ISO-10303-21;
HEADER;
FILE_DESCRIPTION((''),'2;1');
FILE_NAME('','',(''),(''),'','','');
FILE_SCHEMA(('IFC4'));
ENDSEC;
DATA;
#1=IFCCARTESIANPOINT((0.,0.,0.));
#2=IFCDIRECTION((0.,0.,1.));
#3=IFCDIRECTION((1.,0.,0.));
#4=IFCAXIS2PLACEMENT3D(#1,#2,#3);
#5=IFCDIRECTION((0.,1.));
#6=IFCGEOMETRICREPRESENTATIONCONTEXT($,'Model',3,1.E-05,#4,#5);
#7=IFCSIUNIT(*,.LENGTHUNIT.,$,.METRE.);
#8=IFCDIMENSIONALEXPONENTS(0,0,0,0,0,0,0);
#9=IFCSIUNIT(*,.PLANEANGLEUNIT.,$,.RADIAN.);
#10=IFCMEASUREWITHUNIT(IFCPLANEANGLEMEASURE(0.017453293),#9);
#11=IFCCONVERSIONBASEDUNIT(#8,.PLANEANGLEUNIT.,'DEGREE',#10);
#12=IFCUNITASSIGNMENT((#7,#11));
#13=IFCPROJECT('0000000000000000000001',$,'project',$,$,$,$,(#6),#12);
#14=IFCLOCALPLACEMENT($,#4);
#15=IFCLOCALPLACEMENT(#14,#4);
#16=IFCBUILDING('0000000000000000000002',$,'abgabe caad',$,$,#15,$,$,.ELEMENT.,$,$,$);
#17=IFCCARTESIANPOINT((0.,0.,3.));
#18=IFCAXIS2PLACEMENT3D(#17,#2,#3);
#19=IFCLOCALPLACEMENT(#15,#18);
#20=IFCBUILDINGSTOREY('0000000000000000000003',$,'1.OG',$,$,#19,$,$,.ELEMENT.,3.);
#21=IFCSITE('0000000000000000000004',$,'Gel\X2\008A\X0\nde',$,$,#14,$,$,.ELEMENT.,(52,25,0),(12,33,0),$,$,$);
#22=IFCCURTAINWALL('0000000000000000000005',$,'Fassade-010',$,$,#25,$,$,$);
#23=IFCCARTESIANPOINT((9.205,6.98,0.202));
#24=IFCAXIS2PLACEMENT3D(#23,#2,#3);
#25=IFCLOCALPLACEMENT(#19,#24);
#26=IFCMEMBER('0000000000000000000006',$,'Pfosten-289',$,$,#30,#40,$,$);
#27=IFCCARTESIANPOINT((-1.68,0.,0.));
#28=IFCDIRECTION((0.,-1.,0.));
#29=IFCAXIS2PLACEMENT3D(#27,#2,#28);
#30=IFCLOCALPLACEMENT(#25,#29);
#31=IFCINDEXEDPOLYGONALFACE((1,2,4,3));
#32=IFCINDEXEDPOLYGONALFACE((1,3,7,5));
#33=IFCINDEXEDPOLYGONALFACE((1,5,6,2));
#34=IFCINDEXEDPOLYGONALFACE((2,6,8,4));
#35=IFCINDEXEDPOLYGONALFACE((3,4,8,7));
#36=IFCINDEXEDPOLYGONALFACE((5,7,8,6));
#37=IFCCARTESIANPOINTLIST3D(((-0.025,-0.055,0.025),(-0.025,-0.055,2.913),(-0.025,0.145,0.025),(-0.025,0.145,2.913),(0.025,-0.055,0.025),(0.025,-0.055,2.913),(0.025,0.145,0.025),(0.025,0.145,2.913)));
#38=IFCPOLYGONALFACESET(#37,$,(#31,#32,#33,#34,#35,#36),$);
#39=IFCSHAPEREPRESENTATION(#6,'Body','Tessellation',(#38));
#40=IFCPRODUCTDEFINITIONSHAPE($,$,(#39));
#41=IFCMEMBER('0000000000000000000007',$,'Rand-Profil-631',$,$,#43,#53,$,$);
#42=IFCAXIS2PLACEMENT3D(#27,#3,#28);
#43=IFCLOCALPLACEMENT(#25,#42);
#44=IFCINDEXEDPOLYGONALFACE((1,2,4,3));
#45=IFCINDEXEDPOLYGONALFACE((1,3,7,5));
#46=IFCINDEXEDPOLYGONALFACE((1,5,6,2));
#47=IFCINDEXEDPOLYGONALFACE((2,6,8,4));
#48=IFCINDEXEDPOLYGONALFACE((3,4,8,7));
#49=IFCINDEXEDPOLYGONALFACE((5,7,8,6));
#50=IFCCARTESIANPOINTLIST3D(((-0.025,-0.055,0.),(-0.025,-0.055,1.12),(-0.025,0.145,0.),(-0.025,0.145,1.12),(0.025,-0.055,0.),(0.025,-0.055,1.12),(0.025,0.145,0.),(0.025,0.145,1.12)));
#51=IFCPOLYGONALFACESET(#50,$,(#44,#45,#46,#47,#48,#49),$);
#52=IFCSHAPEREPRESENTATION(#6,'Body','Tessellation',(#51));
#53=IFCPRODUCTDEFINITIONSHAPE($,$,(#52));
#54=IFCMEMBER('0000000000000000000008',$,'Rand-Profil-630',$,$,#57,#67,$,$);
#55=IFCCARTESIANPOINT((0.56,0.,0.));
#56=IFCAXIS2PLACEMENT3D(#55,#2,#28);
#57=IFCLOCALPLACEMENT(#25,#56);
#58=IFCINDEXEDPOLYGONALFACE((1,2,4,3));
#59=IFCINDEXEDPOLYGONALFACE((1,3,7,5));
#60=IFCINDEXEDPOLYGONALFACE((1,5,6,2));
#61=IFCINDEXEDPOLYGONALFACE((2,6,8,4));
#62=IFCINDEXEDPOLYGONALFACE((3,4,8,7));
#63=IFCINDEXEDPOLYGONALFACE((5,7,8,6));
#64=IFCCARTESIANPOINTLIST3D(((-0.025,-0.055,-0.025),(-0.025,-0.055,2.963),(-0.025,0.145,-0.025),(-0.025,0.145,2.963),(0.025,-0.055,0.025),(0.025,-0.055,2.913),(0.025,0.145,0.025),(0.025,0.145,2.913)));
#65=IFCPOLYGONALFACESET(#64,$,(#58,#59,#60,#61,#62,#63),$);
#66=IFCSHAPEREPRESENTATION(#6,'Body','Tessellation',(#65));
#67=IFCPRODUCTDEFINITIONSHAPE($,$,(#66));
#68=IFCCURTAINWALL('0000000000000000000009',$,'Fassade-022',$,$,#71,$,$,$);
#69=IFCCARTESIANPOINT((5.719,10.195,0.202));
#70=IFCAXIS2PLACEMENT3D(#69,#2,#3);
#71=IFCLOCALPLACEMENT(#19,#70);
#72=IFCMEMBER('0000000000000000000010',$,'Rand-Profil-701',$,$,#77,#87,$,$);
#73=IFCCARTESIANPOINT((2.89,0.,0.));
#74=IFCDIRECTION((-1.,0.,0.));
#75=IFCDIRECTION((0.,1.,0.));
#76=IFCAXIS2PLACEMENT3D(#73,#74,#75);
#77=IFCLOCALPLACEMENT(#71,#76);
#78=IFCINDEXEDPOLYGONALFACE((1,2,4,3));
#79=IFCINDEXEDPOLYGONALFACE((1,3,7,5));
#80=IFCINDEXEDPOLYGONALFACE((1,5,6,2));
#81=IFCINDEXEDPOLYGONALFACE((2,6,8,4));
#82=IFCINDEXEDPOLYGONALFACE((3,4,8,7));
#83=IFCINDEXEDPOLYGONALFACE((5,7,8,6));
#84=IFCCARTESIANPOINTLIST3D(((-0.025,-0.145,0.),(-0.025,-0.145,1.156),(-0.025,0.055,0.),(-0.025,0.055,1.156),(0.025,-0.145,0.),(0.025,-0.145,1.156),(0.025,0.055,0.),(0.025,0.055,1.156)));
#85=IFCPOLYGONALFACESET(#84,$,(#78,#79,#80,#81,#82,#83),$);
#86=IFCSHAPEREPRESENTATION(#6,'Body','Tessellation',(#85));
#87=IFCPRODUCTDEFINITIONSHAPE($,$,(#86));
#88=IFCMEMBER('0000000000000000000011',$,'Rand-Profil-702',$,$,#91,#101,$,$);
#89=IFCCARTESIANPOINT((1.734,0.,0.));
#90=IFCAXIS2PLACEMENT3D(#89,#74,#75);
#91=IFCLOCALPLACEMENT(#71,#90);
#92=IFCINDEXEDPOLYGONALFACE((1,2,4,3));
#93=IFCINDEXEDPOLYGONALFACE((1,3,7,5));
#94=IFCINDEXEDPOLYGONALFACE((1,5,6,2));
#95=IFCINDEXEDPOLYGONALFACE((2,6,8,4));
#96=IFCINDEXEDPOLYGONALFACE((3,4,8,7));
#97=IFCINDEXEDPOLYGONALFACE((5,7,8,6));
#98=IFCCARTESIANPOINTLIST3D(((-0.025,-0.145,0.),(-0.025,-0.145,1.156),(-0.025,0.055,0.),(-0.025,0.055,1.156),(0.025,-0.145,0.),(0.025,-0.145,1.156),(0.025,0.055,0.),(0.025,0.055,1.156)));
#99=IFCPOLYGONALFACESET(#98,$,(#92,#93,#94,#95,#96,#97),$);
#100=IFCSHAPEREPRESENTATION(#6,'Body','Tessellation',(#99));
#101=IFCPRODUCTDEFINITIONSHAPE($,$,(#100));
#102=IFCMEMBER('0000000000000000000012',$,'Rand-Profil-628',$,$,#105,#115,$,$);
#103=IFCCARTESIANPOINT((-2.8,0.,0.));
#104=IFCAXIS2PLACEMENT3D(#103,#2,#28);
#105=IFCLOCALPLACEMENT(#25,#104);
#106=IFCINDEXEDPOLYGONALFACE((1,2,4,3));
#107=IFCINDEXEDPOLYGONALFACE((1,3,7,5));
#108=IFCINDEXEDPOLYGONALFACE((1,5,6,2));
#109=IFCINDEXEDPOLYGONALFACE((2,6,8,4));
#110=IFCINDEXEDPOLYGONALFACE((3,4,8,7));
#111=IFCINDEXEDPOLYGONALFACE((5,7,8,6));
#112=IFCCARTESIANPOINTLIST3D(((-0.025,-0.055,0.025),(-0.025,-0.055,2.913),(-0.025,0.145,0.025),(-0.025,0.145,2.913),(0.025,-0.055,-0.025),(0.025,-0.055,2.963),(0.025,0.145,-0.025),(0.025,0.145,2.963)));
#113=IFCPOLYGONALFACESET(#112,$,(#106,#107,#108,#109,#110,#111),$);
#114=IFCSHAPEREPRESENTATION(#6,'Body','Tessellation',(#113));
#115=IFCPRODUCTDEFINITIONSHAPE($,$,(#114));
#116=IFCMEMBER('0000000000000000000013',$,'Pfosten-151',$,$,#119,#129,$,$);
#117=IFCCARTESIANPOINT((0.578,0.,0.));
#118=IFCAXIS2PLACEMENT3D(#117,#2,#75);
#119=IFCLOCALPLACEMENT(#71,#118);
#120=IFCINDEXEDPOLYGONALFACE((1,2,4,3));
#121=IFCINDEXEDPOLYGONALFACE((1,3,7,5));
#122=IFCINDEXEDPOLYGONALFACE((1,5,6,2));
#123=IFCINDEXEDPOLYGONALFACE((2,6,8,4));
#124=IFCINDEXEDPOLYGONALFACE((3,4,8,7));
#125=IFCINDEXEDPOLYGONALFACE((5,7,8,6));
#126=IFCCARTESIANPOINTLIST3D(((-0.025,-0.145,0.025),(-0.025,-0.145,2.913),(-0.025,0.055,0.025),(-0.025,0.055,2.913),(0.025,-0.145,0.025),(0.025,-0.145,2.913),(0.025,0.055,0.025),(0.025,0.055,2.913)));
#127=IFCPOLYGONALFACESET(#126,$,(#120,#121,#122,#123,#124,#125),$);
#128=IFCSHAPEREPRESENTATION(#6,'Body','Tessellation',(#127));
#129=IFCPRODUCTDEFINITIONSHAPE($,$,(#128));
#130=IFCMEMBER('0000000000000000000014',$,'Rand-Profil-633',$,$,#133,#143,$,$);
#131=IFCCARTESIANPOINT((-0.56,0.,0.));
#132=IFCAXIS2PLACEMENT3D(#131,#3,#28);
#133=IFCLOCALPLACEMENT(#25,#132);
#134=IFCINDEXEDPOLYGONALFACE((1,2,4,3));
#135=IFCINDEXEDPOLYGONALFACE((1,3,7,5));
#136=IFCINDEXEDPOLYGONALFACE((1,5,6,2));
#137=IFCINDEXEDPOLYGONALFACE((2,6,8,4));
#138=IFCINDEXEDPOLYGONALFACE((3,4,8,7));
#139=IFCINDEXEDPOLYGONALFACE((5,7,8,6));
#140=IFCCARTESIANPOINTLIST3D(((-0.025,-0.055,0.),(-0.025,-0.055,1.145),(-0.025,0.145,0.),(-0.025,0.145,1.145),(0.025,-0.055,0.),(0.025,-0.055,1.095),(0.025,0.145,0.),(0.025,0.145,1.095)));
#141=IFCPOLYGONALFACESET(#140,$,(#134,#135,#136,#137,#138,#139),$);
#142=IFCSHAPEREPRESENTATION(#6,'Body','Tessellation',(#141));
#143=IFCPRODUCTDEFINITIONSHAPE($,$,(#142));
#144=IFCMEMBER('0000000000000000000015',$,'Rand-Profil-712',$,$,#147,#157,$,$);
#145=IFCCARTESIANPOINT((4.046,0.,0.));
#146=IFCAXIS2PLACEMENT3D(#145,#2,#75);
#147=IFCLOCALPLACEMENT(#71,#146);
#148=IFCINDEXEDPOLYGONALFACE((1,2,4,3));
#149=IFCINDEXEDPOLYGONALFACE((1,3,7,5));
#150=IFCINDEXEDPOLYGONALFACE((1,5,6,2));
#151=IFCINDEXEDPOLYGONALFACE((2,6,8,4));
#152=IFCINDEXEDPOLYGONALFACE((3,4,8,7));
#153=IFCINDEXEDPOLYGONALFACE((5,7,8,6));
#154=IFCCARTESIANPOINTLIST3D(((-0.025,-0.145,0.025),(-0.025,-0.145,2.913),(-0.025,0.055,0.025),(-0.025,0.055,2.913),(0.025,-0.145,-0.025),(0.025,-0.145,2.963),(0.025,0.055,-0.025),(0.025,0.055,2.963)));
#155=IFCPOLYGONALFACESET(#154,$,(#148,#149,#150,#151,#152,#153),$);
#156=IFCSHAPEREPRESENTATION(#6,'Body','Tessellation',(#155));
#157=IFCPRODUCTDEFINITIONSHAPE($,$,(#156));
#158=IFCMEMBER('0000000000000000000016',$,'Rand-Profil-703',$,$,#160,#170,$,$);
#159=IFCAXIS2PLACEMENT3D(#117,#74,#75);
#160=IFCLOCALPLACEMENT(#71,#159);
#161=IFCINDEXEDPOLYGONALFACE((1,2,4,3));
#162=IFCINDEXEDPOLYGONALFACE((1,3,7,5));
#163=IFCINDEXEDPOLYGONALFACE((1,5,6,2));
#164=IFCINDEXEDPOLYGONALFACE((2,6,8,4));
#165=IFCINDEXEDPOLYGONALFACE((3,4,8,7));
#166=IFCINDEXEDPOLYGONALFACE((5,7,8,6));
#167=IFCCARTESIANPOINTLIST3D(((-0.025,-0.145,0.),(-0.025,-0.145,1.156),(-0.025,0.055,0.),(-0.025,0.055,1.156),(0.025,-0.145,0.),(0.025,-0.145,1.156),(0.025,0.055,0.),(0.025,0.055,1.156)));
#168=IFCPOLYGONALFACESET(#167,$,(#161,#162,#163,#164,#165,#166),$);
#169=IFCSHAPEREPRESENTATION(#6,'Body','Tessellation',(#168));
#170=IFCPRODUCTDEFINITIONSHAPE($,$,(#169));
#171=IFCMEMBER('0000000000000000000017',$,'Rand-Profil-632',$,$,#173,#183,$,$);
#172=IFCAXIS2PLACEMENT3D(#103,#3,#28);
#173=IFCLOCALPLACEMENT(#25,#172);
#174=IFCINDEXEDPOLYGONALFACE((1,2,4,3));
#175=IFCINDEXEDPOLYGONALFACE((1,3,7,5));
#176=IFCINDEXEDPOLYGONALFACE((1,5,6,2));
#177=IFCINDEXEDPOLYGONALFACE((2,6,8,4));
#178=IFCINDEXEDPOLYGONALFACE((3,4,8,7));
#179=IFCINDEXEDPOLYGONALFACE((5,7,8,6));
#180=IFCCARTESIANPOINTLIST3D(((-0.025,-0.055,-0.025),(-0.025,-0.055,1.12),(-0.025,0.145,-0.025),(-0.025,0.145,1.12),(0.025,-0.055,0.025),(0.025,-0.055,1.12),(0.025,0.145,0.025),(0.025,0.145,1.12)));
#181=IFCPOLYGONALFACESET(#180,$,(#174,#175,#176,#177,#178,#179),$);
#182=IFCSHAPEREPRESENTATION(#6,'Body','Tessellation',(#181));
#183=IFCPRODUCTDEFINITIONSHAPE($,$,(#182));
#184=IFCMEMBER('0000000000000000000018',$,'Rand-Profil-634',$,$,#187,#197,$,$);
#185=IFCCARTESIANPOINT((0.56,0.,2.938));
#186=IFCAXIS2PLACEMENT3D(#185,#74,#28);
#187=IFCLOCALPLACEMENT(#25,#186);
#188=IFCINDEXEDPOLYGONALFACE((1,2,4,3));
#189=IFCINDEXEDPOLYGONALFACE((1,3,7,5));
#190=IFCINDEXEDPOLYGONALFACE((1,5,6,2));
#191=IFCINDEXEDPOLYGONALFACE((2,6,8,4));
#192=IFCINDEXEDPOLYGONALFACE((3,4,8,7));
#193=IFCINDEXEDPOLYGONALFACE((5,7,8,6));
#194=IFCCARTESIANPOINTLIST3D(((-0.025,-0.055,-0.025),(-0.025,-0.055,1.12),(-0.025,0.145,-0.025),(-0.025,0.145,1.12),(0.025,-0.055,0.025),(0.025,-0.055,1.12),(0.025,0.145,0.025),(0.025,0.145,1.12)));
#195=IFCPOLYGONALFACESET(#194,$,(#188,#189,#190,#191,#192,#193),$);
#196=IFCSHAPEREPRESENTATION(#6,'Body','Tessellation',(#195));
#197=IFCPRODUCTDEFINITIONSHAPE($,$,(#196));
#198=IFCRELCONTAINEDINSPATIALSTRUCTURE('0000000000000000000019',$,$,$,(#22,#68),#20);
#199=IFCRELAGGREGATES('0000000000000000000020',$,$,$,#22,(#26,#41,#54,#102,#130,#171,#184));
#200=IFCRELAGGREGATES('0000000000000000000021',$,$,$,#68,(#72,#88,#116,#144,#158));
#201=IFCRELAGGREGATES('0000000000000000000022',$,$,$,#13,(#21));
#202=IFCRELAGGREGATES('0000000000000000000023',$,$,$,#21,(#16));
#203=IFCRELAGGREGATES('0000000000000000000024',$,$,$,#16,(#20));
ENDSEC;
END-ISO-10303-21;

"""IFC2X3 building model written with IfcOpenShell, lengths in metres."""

from ifc_helpers import new_model, entity, si_unit, converted_unit, direction, frame, origin_with_axes, place, context, project, spatial, polyline, outline, extrude, clip, halfspace, element, aggregate, save


model = new_model("IFC2X3")

# Units and contexts
model_context = context("Model", 3, precision=1e-05, world=origin_with_axes(), true_north=direction((0.0, 1.0)))
ifc_project = project(units=[si_unit("LENGTHUNIT", "METRE"), converted_unit("PLANEANGLEUNIT", "DEGREE", entity("IfcPlaneAngleMeasure", 0.017453293), si_unit("PLANEANGLEUNIT", "RADIAN"), dimensions=[0, 0, 0, 0, 0, 0, 0])], contexts=[model_context])

# Site, building, storey
site_placement = place(None, origin_with_axes())
site = spatial("IfcSite", under=ifc_project, at=site_placement, Name="Gel\u008ande", CompositionType="ELEMENT", RefLatitude=(52, 25, 0), RefLongitude=(12, 33, 0))
building_placement = place(site_placement, origin_with_axes())
building = spatial("IfcBuilding", under=site, at=building_placement, Name="abgabe caad", CompositionType="ELEMENT")
storey_placement = place(building_placement, frame((0.0, 0.0, 3.0), z_axis=(0.0, 0.0, 1.0), x_axis=(1.0, 0.0, 0.0)))
storey = spatial("IfcBuildingStorey", under=building, at=storey_placement, Name="1.OG", CompositionType="ELEMENT", Elevation=3.0)

# Curtain walls, members
curtain_wall_1_placement = place(storey_placement, frame((9.205, 6.98, 0.202), z_axis=(0.0, 0.0, 1.0), x_axis=(1.0, 0.0, 0.0)))
curtain_wall_1 = element("IfcCurtainWall", 1, at=curtain_wall_1_placement, inside=storey, Name="Fassade-010")
member_1_placement = place(curtain_wall_1_placement, frame((-1.68, 0.0, 0.0), z_axis=(0.0, 0.0, 1.0), x_axis=(0.0, -1.0, 0.0)))
member_1 = element("IfcMember", 2, at=member_1_placement, Name="Pfosten-289", context=model_context, shape_type="SweptSolid", body=[
    extrude(outline(polyline([(0.145, -0.025), (0.145, 0.025), (-0.055, 0.025), (-0.055, -0.025), (0.145, -0.025)])), frame((0.0, 0.0, 0.025), z_axis=(0.0, 0.0, 1.0), x_axis=(0.0, 1.0, 0.0)), (0.0, 0.0, 1.0), 2.888),
])
member_2_placement = place(curtain_wall_1_placement, frame((-1.68, 0.0, 0.0), z_axis=(1.0, 0.0, 0.0), x_axis=(0.0, -1.0, 0.0)))
member_2 = element("IfcMember", 3, at=member_2_placement, Name="Rand-Profil-631", context=model_context, shape_type="SweptSolid", body=[
    extrude(outline(polyline([(0.025, 0.145), (-0.025, 0.145), (-0.025, -0.055), (0.025, -0.055), (0.025, 0.145)])), origin_with_axes(), (0.0, 0.0, 1.0), 1.12),
])
member_3_placement = place(curtain_wall_1_placement, frame((0.56, 0.0, 0.0), z_axis=(0.0, 0.0, 1.0), x_axis=(0.0, -1.0, 0.0)))
member_3 = element("IfcMember", 4, at=member_3_placement, Name="Rand-Profil-630", context=model_context, shape_type="Clipping", body=[
    clip(clip(extrude(outline(polyline([(0.145, -0.025), (0.145, 0.025), (-0.055, 0.025), (-0.055, -0.025), (0.145, -0.025)])), frame((0.0, 0.0, -0.025), z_axis=(0.0, 0.0, 1.0), x_axis=(0.0, 1.0, 0.0)), (0.0, 0.0, 1.0), 2.988), halfspace(frame((0.0, 0.0, 0.0), z_axis=(-0.707107, 0.0, 0.707107), x_axis=(-0.707107, 0.0, -0.707107)), True)), halfspace(frame((1.469, 0.0, 1.469), z_axis=(-0.707107, 0.0, -0.707107), x_axis=(0.707107, 0.0, -0.707107)), True)),
])
curtain_wall_2_placement = place(storey_placement, frame((5.719, 10.195, 0.202), z_axis=(0.0, 0.0, 1.0), x_axis=(1.0, 0.0, 0.0)))
curtain_wall_2 = element("IfcCurtainWall", 5, at=curtain_wall_2_placement, inside=storey, Name="Fassade-022")
member_4_placement = place(curtain_wall_2_placement, frame((2.89, 0.0, 0.0), z_axis=(-1.0, 0.0, 0.0), x_axis=(0.0, 1.0, 0.0)))
member_4 = element("IfcMember", 6, at=member_4_placement, Name="Rand-Profil-701", context=model_context, shape_type="SweptSolid", body=[
    extrude(outline(polyline([(0.025, -0.145), (0.025, 0.055), (-0.025, 0.055), (-0.025, -0.145), (0.025, -0.145)])), origin_with_axes(), (0.0, 0.0, 1.0), 1.156),
])
member_5_placement = place(curtain_wall_2_placement, frame((1.734, 0.0, 0.0), z_axis=(-1.0, 0.0, 0.0), x_axis=(0.0, 1.0, 0.0)))
member_5 = element("IfcMember", 7, at=member_5_placement, Name="Rand-Profil-702", context=model_context, shape_type="SweptSolid", body=[
    extrude(outline(polyline([(0.025, -0.145), (0.025, 0.055), (-0.025, 0.055), (-0.025, -0.145), (0.025, -0.145)])), origin_with_axes(), (0.0, 0.0, 1.0), 1.156),
])

# Members
member_6_placement = place(curtain_wall_1_placement, frame((-2.8, 0.0, 0.0), z_axis=(0.0, 0.0, 1.0), x_axis=(0.0, -1.0, 0.0)))
member_6 = element("IfcMember", 8, at=member_6_placement, Name="Rand-Profil-628", context=model_context, shape_type="Clipping", body=[
    clip(clip(extrude(outline(polyline([(0.145, -0.025), (0.145, 0.025), (-0.055, 0.025), (-0.055, -0.025), (0.145, -0.025)])), frame((0.0, 0.0, -0.025), z_axis=(0.0, 0.0, 1.0), x_axis=(0.0, 1.0, 0.0)), (0.0, 0.0, 1.0), 2.988), halfspace(frame((0.0, 0.0, 0.0), z_axis=(0.707107, 0.0, 0.707107), x_axis=(-0.707107, 0.0, 0.707107)), True)), halfspace(frame((-1.469, 0.0, 1.469), z_axis=(0.707107, 0.0, -0.707107), x_axis=(0.707107, 0.0, 0.707107)), True)),
])
member_7_placement = place(curtain_wall_2_placement, frame((0.578, 0.0, 0.0), z_axis=(0.0, 0.0, 1.0), x_axis=(0.0, 1.0, 0.0)))
member_7 = element("IfcMember", 9, at=member_7_placement, Name="Pfosten-151", context=model_context, shape_type="SweptSolid", body=[
    extrude(outline(polyline([(0.145, 0.025), (-0.055, 0.025), (-0.055, -0.025), (0.145, -0.025), (0.145, 0.025)])), frame((0.0, 0.0, 0.025), z_axis=(0.0, 0.0, 1.0), x_axis=(0.0, -1.0, 0.0)), (0.0, 0.0, 1.0), 2.888),
])
member_8_placement = place(curtain_wall_1_placement, frame((-0.56, 0.0, 0.0), z_axis=(1.0, 0.0, 0.0), x_axis=(0.0, -1.0, 0.0)))
member_8 = element("IfcMember", 10, at=member_8_placement, Name="Rand-Profil-633", context=model_context, shape_type="Clipping", body=[
    clip(extrude(outline(polyline([(0.025, 0.145), (-0.025, 0.145), (-0.025, -0.055), (0.025, -0.055), (0.025, 0.145)])), origin_with_axes(), (0.0, 0.0, 1.0), 1.145), halfspace(frame((0.56, 0.0, 0.56), z_axis=(-0.707107, 0.0, -0.707107), x_axis=(0.707107, 0.0, -0.707107)), True)),
])
member_9_placement = place(curtain_wall_2_placement, frame((4.046, 0.0, 0.0), z_axis=(0.0, 0.0, 1.0), x_axis=(0.0, 1.0, 0.0)))
member_9 = element("IfcMember", 11, at=member_9_placement, Name="Rand-Profil-712", context=model_context, shape_type="Clipping", body=[
    clip(clip(extrude(outline(polyline([(0.145, 0.025), (-0.055, 0.025), (-0.055, -0.025), (0.145, -0.025), (0.145, 0.025)])), frame((0.0, 0.0, -0.025), z_axis=(0.0, 0.0, 1.0), x_axis=(0.0, -1.0, 0.0)), (0.0, 0.0, 1.0), 2.988), halfspace(frame((0.0, 0.0, 0.0), z_axis=(0.707107, 0.0, 0.707107), x_axis=(-0.707107, 0.0, 0.707107)), True)), halfspace(frame((-1.469, 0.0, 1.469), z_axis=(0.707107, 0.0, -0.707107), x_axis=(0.707107, 0.0, 0.707107)), True)),
])
member_10_placement = place(curtain_wall_2_placement, frame((0.578, 0.0, 0.0), z_axis=(-1.0, 0.0, 0.0), x_axis=(0.0, 1.0, 0.0)))
member_10 = element("IfcMember", 12, at=member_10_placement, Name="Rand-Profil-703", context=model_context, shape_type="SweptSolid", body=[
    extrude(outline(polyline([(0.025, -0.145), (0.025, 0.055), (-0.025, 0.055), (-0.025, -0.145), (0.025, -0.145)])), origin_with_axes(), (0.0, 0.0, 1.0), 1.156),
])
member_11_placement = place(curtain_wall_1_placement, frame((-2.8, 0.0, 0.0), z_axis=(1.0, 0.0, 0.0), x_axis=(0.0, -1.0, 0.0)))
member_11 = element("IfcMember", 13, at=member_11_placement, Name="Rand-Profil-632", context=model_context, shape_type="Clipping", body=[
    clip(extrude(outline(polyline([(0.025, 0.145), (-0.025, 0.145), (-0.025, -0.055), (0.025, -0.055), (0.025, 0.145)])), frame((0.0, 0.0, -0.025), z_axis=(0.0, 0.0, 1.0), x_axis=(1.0, 0.0, 0.0)), (0.0, 0.0, 1.0), 1.145), halfspace(frame((0.0, 0.0, 0.0), z_axis=(-0.707107, 0.0, 0.707107), x_axis=(-0.707107, 0.0, -0.707107)), True)),
])
member_12_placement = place(curtain_wall_1_placement, frame((0.56, 0.0, 2.938), z_axis=(-1.0, 0.0, 0.0), x_axis=(0.0, -1.0, 0.0)))
member_12 = element("IfcMember", 14, at=member_12_placement, Name="Rand-Profil-634", context=model_context, shape_type="Clipping", body=[
    clip(extrude(outline(polyline([(-0.025, -0.145), (0.025, -0.145), (0.025, 0.055), (-0.025, 0.055), (-0.025, -0.145)])), frame((0.0, 0.0, -0.025), z_axis=(0.0, 0.0, 1.0), x_axis=(-1.0, 0.0, 0.0)), (0.0, 0.0, 1.0), 1.145), halfspace(frame((0.0, 0.0, 0.0), z_axis=(-0.707107, 0.0, 0.707107), x_axis=(-0.707107, 0.0, -0.707107)), True)),
])

aggregate(curtain_wall_1, [member_1, member_2, member_3, member_6, member_8, member_11, member_12])
aggregate(curtain_wall_2, [member_4, member_5, member_7, member_9, member_10])

save(model, "model.ifc")
